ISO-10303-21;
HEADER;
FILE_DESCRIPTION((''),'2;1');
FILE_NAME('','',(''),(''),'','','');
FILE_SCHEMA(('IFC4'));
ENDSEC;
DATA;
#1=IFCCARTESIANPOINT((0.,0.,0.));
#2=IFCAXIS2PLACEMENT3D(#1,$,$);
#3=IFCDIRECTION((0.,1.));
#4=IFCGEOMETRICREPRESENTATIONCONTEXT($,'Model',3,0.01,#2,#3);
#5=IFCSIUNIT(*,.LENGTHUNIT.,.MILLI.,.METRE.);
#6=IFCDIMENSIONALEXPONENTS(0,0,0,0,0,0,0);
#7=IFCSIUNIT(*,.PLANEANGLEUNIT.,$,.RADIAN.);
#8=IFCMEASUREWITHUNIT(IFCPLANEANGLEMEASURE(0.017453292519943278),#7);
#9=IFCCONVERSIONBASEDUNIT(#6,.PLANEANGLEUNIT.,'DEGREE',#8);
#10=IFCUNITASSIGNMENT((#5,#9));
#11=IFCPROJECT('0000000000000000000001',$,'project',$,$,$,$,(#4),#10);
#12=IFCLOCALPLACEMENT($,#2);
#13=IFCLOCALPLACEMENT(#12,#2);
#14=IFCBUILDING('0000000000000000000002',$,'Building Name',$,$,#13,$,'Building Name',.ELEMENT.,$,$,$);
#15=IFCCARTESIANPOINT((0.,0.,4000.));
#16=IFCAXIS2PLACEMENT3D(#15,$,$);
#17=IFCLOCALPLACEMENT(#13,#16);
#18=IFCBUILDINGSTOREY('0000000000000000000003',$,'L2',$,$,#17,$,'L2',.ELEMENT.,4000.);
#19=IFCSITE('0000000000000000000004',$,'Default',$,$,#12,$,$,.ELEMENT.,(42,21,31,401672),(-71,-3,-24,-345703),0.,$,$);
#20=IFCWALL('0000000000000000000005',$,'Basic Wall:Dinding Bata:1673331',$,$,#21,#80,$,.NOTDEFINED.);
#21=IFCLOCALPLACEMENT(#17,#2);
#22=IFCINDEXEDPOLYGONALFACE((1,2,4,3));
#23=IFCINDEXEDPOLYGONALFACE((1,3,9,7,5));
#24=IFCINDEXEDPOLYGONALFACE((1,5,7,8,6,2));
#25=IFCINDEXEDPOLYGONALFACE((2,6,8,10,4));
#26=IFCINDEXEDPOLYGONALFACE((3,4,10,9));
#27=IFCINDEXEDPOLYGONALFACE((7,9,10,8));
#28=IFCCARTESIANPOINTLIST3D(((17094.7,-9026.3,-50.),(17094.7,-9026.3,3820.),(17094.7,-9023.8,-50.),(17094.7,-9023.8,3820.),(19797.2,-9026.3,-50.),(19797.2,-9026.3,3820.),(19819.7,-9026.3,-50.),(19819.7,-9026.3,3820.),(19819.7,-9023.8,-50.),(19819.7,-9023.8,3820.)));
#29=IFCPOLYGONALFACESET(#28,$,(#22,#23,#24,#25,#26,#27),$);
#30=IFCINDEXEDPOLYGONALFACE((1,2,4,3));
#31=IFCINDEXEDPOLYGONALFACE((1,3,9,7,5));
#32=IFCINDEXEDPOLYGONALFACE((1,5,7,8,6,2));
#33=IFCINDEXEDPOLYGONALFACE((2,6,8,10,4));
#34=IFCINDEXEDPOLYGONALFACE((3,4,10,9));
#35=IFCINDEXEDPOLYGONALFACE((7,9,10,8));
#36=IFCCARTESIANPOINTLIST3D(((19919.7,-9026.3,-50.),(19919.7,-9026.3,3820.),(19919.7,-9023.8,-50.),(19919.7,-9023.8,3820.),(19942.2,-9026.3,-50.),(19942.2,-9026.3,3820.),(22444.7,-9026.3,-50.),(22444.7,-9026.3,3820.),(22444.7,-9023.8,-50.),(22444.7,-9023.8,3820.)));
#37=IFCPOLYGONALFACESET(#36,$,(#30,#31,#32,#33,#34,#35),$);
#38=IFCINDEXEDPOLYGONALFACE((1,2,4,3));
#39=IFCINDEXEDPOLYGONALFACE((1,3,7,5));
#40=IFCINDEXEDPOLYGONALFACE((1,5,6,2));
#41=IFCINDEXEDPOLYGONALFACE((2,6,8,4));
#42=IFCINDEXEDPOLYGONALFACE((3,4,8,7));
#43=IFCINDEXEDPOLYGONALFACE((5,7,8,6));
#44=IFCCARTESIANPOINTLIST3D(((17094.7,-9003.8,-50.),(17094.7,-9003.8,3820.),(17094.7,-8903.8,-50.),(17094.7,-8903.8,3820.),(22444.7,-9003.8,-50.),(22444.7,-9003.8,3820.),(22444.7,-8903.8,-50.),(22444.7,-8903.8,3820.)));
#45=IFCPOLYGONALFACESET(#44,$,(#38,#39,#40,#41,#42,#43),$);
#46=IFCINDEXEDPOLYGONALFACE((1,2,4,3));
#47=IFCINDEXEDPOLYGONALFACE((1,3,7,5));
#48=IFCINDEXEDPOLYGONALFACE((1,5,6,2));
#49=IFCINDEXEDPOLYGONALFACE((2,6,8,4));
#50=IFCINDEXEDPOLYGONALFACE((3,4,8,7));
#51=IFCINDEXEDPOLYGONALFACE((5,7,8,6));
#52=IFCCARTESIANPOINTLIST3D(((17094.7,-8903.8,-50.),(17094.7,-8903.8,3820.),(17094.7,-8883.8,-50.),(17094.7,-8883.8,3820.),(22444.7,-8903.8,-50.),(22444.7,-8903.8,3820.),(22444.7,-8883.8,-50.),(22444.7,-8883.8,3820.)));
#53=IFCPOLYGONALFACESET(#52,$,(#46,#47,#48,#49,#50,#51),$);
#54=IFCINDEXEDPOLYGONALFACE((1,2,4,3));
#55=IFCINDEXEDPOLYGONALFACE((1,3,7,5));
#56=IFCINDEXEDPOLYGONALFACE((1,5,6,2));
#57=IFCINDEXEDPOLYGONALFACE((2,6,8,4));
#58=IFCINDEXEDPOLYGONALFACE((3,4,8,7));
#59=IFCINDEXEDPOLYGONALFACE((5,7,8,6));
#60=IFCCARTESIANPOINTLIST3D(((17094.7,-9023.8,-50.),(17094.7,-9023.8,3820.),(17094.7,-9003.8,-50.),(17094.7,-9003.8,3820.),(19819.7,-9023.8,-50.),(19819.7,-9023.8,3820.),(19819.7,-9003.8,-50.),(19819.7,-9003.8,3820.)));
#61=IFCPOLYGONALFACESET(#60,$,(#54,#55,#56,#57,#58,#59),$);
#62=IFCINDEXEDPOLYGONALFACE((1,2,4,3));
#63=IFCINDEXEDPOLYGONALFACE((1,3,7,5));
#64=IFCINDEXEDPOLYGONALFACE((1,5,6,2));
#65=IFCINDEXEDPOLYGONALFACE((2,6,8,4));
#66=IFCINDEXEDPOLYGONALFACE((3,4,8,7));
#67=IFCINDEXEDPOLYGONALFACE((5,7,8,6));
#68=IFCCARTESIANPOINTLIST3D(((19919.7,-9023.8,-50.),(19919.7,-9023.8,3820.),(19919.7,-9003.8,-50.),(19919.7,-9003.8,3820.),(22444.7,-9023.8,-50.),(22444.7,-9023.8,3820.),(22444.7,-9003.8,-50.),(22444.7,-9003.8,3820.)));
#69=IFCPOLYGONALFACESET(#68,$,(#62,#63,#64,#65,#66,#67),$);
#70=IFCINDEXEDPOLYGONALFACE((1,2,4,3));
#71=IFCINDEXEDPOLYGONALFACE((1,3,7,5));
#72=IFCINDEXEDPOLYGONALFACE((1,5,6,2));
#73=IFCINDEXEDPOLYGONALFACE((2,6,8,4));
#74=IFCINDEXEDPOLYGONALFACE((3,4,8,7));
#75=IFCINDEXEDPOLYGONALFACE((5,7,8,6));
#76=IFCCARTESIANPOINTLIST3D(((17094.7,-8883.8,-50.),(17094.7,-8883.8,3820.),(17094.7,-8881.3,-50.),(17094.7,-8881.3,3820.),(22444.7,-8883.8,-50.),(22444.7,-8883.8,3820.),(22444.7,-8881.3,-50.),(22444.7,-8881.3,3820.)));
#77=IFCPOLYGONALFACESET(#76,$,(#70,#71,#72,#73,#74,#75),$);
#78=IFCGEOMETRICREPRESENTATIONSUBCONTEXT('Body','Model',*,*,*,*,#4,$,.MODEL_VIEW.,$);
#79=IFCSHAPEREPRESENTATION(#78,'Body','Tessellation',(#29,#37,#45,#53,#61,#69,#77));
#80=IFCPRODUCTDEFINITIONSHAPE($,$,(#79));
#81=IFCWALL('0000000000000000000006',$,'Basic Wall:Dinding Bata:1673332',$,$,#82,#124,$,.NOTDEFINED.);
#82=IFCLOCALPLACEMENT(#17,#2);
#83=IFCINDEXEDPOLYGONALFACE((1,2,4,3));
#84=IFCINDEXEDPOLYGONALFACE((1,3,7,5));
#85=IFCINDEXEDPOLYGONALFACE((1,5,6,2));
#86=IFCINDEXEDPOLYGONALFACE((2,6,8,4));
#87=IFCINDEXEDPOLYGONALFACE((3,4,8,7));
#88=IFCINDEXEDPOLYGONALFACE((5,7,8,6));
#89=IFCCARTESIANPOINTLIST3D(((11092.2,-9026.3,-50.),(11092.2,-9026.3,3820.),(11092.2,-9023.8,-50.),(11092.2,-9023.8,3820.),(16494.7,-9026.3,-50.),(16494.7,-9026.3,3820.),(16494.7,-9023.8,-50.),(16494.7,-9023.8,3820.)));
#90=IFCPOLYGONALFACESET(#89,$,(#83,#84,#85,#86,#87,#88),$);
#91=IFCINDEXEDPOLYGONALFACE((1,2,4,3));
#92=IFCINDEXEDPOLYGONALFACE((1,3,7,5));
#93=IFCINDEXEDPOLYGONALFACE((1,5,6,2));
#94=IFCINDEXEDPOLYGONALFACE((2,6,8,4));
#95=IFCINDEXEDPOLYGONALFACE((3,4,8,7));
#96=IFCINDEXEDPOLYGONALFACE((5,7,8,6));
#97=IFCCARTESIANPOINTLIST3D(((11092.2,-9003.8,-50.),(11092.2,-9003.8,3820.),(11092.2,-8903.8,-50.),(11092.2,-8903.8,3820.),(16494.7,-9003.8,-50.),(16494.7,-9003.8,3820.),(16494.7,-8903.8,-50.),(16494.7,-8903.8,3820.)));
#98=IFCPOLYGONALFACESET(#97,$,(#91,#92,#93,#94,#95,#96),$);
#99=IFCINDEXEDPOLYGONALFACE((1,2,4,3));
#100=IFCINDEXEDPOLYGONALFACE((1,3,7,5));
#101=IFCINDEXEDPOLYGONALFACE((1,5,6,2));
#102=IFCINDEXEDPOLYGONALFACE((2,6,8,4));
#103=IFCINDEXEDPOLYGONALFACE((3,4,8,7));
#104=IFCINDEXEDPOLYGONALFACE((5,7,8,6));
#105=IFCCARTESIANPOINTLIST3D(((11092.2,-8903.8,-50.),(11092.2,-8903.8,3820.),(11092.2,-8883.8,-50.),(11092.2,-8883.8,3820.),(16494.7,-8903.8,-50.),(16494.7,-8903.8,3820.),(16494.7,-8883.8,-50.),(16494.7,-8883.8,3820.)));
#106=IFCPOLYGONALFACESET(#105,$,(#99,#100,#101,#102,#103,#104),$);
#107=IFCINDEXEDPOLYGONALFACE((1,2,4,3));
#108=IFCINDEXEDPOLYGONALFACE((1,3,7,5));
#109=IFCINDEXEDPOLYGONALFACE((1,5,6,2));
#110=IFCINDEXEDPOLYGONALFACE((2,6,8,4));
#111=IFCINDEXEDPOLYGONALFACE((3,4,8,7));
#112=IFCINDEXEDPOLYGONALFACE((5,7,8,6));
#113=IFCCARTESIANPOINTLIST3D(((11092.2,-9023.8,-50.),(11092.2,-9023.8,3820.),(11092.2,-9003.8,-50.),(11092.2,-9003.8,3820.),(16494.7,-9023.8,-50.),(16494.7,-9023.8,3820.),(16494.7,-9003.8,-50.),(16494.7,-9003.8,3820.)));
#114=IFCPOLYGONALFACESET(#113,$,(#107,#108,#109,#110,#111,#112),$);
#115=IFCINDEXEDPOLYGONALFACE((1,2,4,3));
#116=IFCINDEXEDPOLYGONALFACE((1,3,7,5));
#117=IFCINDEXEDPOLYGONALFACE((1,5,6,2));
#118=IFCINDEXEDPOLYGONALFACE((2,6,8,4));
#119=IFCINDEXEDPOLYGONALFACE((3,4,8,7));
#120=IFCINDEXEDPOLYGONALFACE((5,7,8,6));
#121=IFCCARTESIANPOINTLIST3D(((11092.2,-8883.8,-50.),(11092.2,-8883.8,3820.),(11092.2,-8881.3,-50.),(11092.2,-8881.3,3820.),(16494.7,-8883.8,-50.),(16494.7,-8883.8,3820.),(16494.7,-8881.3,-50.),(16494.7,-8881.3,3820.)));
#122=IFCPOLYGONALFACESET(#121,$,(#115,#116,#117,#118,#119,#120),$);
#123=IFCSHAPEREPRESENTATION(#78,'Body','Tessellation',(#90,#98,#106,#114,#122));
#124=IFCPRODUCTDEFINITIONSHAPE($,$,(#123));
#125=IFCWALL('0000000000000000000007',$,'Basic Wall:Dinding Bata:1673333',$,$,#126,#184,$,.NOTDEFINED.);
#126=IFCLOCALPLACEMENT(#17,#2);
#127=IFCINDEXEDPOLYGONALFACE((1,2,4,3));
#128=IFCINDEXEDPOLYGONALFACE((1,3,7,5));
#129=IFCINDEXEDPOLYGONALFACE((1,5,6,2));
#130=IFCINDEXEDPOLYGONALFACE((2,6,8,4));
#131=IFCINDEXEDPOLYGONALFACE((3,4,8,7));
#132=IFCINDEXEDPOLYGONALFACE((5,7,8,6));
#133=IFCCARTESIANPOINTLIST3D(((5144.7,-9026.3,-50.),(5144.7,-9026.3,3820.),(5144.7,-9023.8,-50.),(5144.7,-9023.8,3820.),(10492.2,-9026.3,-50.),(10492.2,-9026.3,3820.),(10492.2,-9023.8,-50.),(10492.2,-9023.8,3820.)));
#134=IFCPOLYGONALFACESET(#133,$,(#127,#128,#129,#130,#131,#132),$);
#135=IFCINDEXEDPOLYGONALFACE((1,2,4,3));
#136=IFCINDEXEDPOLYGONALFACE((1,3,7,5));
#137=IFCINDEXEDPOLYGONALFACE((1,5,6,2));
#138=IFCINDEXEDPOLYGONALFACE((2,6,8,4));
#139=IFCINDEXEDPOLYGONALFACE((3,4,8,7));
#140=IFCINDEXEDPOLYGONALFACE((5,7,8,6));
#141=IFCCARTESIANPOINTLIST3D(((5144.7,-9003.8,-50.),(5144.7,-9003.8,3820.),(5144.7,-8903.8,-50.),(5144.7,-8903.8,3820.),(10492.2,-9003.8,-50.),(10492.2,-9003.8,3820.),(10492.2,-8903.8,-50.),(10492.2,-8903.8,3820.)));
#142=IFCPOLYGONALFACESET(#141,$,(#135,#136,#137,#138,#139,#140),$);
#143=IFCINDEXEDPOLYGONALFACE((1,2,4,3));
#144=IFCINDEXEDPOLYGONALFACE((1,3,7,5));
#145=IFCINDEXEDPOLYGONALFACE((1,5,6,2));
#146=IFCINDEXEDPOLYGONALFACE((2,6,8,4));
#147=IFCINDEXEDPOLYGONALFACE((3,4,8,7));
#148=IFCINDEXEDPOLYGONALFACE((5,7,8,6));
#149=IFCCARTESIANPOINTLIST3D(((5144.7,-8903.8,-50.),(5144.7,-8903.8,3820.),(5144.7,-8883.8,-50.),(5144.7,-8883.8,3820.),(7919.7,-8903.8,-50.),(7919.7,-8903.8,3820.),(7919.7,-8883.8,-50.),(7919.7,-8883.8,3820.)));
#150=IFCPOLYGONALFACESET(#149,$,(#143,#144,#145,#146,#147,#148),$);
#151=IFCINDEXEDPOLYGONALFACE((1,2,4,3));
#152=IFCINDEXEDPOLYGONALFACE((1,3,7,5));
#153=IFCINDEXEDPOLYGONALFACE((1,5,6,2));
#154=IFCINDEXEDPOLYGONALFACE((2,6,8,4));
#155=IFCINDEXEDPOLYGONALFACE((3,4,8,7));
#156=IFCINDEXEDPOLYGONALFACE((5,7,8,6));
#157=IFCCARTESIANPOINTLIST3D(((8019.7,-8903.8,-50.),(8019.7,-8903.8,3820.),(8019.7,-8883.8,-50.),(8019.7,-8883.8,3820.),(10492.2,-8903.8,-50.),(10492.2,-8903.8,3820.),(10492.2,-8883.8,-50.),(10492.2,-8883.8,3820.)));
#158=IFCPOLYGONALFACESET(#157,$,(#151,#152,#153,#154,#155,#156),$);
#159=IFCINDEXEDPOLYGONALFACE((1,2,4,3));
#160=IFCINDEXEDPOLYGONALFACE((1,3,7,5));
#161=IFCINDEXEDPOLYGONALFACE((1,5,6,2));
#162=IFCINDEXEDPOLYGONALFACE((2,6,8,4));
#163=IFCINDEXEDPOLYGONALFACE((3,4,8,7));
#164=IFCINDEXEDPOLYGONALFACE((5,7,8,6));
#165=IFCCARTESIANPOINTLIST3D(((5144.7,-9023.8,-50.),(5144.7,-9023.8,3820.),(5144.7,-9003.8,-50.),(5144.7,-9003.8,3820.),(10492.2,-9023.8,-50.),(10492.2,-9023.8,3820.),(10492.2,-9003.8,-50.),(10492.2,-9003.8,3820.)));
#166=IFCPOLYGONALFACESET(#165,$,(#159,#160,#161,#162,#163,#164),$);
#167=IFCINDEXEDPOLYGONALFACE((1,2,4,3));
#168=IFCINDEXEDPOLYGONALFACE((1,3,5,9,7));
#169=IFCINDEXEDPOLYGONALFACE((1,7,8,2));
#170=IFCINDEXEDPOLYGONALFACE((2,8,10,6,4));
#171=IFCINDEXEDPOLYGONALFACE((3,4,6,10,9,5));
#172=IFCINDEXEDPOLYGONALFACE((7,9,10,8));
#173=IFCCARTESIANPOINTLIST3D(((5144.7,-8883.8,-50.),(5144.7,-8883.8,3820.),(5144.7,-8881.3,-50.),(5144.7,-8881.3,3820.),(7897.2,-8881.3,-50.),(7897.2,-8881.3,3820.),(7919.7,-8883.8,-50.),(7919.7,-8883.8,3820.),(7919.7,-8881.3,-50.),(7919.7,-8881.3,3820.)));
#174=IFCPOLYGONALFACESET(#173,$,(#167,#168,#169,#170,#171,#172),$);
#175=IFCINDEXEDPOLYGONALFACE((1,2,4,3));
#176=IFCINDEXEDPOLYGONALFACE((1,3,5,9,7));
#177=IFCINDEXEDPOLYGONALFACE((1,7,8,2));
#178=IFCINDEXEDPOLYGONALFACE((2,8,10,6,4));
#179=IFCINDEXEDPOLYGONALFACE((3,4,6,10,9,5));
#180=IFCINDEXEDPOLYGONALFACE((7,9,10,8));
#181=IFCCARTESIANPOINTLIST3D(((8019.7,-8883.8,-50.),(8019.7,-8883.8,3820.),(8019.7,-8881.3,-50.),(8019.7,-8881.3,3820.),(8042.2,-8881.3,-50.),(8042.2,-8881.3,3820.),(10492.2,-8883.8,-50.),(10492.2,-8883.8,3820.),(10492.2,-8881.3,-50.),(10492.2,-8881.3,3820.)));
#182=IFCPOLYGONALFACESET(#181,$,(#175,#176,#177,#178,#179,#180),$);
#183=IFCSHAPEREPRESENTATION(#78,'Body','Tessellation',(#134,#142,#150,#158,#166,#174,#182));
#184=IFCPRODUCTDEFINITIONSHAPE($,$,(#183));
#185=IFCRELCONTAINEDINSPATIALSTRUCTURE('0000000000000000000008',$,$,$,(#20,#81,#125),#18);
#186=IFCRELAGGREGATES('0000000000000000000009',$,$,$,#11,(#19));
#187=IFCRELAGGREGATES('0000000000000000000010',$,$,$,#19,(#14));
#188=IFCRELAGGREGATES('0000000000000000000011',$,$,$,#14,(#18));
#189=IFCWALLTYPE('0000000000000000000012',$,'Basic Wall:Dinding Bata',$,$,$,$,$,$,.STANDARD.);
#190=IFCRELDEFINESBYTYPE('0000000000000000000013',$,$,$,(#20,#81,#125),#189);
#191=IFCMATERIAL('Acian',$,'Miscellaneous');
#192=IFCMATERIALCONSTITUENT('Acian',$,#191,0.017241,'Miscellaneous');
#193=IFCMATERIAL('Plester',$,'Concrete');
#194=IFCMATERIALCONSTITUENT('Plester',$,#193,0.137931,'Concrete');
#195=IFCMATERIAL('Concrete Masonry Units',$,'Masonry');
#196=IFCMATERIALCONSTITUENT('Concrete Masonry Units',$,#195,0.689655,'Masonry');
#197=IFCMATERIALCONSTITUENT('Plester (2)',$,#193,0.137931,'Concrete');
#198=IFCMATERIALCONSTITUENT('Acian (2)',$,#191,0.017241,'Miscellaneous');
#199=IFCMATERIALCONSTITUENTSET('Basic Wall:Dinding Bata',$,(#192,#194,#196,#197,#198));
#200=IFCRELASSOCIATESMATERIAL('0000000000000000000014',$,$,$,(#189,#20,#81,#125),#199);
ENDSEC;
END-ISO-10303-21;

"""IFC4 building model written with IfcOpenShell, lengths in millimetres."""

from ifc_helpers import new_model, entity, si_unit, converted_unit, direction, frame, origin, place, context, subcontext, project, spatial, indexed_curve, outline, extrude, material, constituent, constituent_set, type_object, element, save


model = new_model("IFC4")

# Units and contexts
model_context = context("Model", 3, precision=0.01, world=origin(), true_north=direction((0.0, 1.0)))
body_context = subcontext(model_context, "Body", "Model", "MODEL_VIEW")
ifc_project = project(units=[si_unit("LENGTHUNIT", "METRE", prefix="MILLI"), converted_unit("PLANEANGLEUNIT", "DEGREE", entity("IfcPlaneAngleMeasure", 0.017453292519943278), si_unit("PLANEANGLEUNIT", "RADIAN"), dimensions=[0, 0, 0, 0, 0, 0, 0])], contexts=[model_context])

# Site, building, storey
site_placement = place(None, origin())
site = spatial("IfcSite", under=ifc_project, at=site_placement, Name="Default", CompositionType="ELEMENT", RefLatitude=(42, 21, 31, 401672), RefLongitude=(-71, -3, -24, -345703), RefElevation=0.0)
building_placement = place(site_placement, origin())
building = spatial("IfcBuilding", under=site, at=building_placement, Name="Building Name", LongName="Building Name", CompositionType="ELEMENT")
storey_placement = place(building_placement, frame((0.0, 0.0, 4000.0)))
storey = spatial("IfcBuildingStorey", under=building, at=storey_placement, Name="L2", LongName="L2", CompositionType="ELEMENT", Elevation=4000.0)

# Walls
ifc_material_1 = material(Name="Acian", Category="Miscellaneous")
ifc_constituent_1 = constituent(ifc_material_1, Name="Acian", Category="Miscellaneous", fraction=0.017241)
ifc_material_2 = material(Name="Plester", Category="Concrete")
ifc_constituent_2 = constituent(ifc_material_2, Name="Plester", Category="Concrete", fraction=0.137931)
ifc_material_3 = material(Name="Concrete Masonry Units", Category="Masonry")
ifc_constituent_3 = constituent(ifc_material_3, Name="Concrete Masonry Units", Category="Masonry", fraction=0.689655)
ifc_constituent_4 = constituent(ifc_material_2, Name="Plester (2)", Category="Concrete", fraction=0.137931)
ifc_constituent_5 = constituent(ifc_material_1, Name="Acian (2)", Category="Miscellaneous", fraction=0.017241)
ifc_constituent_set = constituent_set(constituents=[ifc_constituent_1, ifc_constituent_2, ifc_constituent_3, ifc_constituent_4, ifc_constituent_5], Name="Basic Wall:Dinding Bata")
wall_type = type_object("IfcWallType", Name="Basic Wall:Dinding Bata", PredefinedType="STANDARD", material=ifc_constituent_set)
wall_1_placement = place(storey_placement, frame((22444.7, -8953.8, -50.0), z_axis=(0.0, 0.0, 1.0), x_axis=(-1.0, 0.0, 0.0)))
element("IfcWall", 1, at=wall_1_placement, inside=storey, type_object=wall_type, material=ifc_constituent_set, Name="Basic Wall:Dinding Bata:1673331", PredefinedType="NOTDEFINED", context=body_context, shape_type="SweptSolid", body=[
    extrude(outline(indexed_curve([(1072.0, -1.0), (1094.5, -1.0), (1094.5, 1.5), (-1630.5, 1.5), (-1630.5, -1.0), (1072.0, -1.0)], self_intersect=False)), frame((3719.5, 71.5, 0.0), z_axis=(0.0, 0.0, 1.0), x_axis=(-1.0, 0.0, 0.0)), (0.0, 0.0, 1.0), 3870.0),
    extrude(outline(indexed_curve([(-1510.5, -1.5), (1014.5, -1.5), (1014.5, 1.0), (992.0, 1.0), (-1510.5, 1.0), (-1510.5, -1.5)], self_intersect=False)), frame((1510.5, 71.5, 0.0)), (0.0, 0.0, 1.0), 3870.0),
    extrude(outline(indexed_curve([(-2675.0, -50.0), (2675.0, -50.0), (2675.0, 50.0), (-2675.0, 50.0), (-2675.0, -50.0)], self_intersect=False)), frame((2675.0, 0.0, 0.0)), (0.0, 0.0, 1.0), 3870.0),
    extrude(outline(indexed_curve([(-2675.0, -10.0), (2675.0, -10.0), (2675.0, 10.0), (-2675.0, 10.0), (-2675.0, -10.0)], self_intersect=False)), frame((2675.0, -60.0, 0.0)), (0.0, 0.0, 1.0), 3870.0),
    extrude(outline(indexed_curve([(-1362.5, -10.0), (1362.5, -10.0), (1362.5, 10.0), (-1362.5, 10.0), (-1362.5, -10.0)], self_intersect=False)), frame((3987.5, 60.0, 0.0), z_axis=(0.0, 0.0, 1.0), x_axis=(-1.0, 0.0, 0.0)), (0.0, 0.0, 1.0), 3870.0),
    extrude(outline(indexed_curve([(-1262.5, -10.0), (1262.5, -10.0), (1262.5, 10.0), (-1262.5, 10.0), (-1262.5, -10.0)], self_intersect=False)), frame((1262.5, 60.0, 0.0)), (0.0, 0.0, 1.0), 3870.0),
    extrude(outline(indexed_curve([(-1.3, -2675.0), (1.2, -2675.0), (1.3, 2675.0), (-1.2, 2675.0), (-1.3, -2675.0)], self_intersect=False)), frame((2675.0, -71.3, 0.0), z_axis=(0.0, 0.0, 1.0), x_axis=(0.0, 1.0, 0.0)), (0.0, 0.0, 1.0), 3870.0),
])
wall_2_placement = place(storey_placement, frame((16494.7, -8953.8, -50.0), z_axis=(0.0, 0.0, 1.0), x_axis=(-1.0, 0.0, 0.0)))
element("IfcWall", 2, at=wall_2_placement, inside=storey, type_object=wall_type, material=ifc_constituent_set, Name="Basic Wall:Dinding Bata:1673332", PredefinedType="NOTDEFINED", context=body_context, shape_type="SweptSolid", body=[
    extrude(outline(indexed_curve([(-1.3, -2701.2), (1.2, -2701.2), (1.3, 2701.2), (-1.2, 2701.2), (-1.3, -2701.2)], self_intersect=False)), frame((2701.2, 71.3, 0.0), z_axis=(0.0, 0.0, 1.0), x_axis=(0.0, -1.0, 0.0)), (0.0, 0.0, 1.0), 3870.0),
    extrude(outline(indexed_curve([(-2701.2, -50.0), (2701.2, -50.0), (2701.2, 50.0), (-2701.2, 50.0), (-2701.2, -50.0)], self_intersect=False)), frame((2701.2, 0.0, 0.0)), (0.0, 0.0, 1.0), 3870.0),
    extrude(outline(indexed_curve([(-2701.2, -10.0), (2701.2, -10.0), (2701.2, 10.0), (-2701.2, 10.0), (-2701.2, -10.0)], self_intersect=False)), frame((2701.2, -60.0, 0.0)), (0.0, 0.0, 1.0), 3870.0),
    extrude(outline(indexed_curve([(-2701.2, -10.0), (2701.2, -10.0), (2701.2, 10.0), (-2701.2, 10.0), (-2701.2, -10.0)], self_intersect=False)), frame((2701.2, 60.0, 0.0)), (0.0, 0.0, 1.0), 3870.0),
    extrude(outline(indexed_curve([(-1.3, -2701.2), (1.2, -2701.2), (1.3, 2701.2), (-1.2, 2701.2), (-1.3, -2701.2)], self_intersect=False)), frame((2701.2, -71.2, 0.0), z_axis=(0.0, 0.0, 1.0), x_axis=(0.0, 1.0, 0.0)), (0.0, 0.0, 1.0), 3870.0),
])
wall_3_placement = place(storey_placement, frame((10492.2, -8953.8, -50.0), z_axis=(0.0, 0.0, 1.0), x_axis=(-1.0, 0.0, 0.0)))
element("IfcWall", 3, at=wall_3_placement, inside=storey, type_object=wall_type, material=ifc_constituent_set, Name="Basic Wall:Dinding Bata:1673333", PredefinedType="NOTDEFINED", context=body_context, shape_type="SweptSolid", body=[
    extrude(outline(indexed_curve([(-1.3, -2673.8), (1.2, -2673.8), (1.3, 2673.8), (-1.2, 2673.8), (-1.3, -2673.8)], self_intersect=False)), frame((2673.8, 71.3, 0.0), z_axis=(0.0, 0.0, 1.0), x_axis=(0.0, -1.0, 0.0)), (0.0, 0.0, 1.0), 3870.0),
    extrude(outline(indexed_curve([(-2673.8, -50.0), (2673.8, -50.0), (2673.8, 50.0), (-2673.8, 50.0), (-2673.8, -50.0)], self_intersect=False)), frame((2673.8, 0.0, 0.0)), (0.0, 0.0, 1.0), 3870.0),
    extrude(outline(indexed_curve([(-1387.5, -10.0), (1387.5, -10.0), (1387.5, 10.0), (-1387.5, 10.0), (-1387.5, -10.0)], self_intersect=False)), frame((3960.0, -60.0, 0.0), z_axis=(0.0, 0.0, 1.0), x_axis=(-1.0, 0.0, 0.0)), (0.0, 0.0, 1.0), 3870.0),
    extrude(outline(indexed_curve([(-1236.3, -10.0), (1236.3, -10.0), (1236.3, 10.0), (-1236.3, 10.0), (-1236.3, -10.0)], self_intersect=False)), frame((1236.3, -60.0, 0.0)), (0.0, 0.0, 1.0), 3870.0),
    extrude(outline(indexed_curve([(-2673.8, -10.0), (2673.8, -10.0), (2673.8, 10.0), (-2673.8, 10.0), (-2673.8, -10.0)], self_intersect=False)), frame((2673.8, 60.0, 0.0)), (0.0, 0.0, 1.0), 3870.0),
    extrude(outline(indexed_curve([(-1.0, -1660.5), (1.5, -1660.5), (1.5, 1114.5), (-1.0, 1114.5), (-1.0, 1092.0), (-1.0, -1660.5)], self_intersect=False)), frame((3687.0, -71.5, 0.0), z_axis=(0.0, 0.0, 1.0), x_axis=(0.0, 1.0, 0.0)), (0.0, 0.0, 1.0), 3870.0),
    extrude(outline(indexed_curve([(971.0, -1.0), (993.5, -1.0), (993.5, 1.5), (-1479.0, 1.5), (-1479.0, -1.0), (971.0, -1.0)], self_intersect=False)), frame((1479.0, -71.5, 0.0)), (0.0, 0.0, 1.0), 3870.0),
])

save(model, "model.ifc")
